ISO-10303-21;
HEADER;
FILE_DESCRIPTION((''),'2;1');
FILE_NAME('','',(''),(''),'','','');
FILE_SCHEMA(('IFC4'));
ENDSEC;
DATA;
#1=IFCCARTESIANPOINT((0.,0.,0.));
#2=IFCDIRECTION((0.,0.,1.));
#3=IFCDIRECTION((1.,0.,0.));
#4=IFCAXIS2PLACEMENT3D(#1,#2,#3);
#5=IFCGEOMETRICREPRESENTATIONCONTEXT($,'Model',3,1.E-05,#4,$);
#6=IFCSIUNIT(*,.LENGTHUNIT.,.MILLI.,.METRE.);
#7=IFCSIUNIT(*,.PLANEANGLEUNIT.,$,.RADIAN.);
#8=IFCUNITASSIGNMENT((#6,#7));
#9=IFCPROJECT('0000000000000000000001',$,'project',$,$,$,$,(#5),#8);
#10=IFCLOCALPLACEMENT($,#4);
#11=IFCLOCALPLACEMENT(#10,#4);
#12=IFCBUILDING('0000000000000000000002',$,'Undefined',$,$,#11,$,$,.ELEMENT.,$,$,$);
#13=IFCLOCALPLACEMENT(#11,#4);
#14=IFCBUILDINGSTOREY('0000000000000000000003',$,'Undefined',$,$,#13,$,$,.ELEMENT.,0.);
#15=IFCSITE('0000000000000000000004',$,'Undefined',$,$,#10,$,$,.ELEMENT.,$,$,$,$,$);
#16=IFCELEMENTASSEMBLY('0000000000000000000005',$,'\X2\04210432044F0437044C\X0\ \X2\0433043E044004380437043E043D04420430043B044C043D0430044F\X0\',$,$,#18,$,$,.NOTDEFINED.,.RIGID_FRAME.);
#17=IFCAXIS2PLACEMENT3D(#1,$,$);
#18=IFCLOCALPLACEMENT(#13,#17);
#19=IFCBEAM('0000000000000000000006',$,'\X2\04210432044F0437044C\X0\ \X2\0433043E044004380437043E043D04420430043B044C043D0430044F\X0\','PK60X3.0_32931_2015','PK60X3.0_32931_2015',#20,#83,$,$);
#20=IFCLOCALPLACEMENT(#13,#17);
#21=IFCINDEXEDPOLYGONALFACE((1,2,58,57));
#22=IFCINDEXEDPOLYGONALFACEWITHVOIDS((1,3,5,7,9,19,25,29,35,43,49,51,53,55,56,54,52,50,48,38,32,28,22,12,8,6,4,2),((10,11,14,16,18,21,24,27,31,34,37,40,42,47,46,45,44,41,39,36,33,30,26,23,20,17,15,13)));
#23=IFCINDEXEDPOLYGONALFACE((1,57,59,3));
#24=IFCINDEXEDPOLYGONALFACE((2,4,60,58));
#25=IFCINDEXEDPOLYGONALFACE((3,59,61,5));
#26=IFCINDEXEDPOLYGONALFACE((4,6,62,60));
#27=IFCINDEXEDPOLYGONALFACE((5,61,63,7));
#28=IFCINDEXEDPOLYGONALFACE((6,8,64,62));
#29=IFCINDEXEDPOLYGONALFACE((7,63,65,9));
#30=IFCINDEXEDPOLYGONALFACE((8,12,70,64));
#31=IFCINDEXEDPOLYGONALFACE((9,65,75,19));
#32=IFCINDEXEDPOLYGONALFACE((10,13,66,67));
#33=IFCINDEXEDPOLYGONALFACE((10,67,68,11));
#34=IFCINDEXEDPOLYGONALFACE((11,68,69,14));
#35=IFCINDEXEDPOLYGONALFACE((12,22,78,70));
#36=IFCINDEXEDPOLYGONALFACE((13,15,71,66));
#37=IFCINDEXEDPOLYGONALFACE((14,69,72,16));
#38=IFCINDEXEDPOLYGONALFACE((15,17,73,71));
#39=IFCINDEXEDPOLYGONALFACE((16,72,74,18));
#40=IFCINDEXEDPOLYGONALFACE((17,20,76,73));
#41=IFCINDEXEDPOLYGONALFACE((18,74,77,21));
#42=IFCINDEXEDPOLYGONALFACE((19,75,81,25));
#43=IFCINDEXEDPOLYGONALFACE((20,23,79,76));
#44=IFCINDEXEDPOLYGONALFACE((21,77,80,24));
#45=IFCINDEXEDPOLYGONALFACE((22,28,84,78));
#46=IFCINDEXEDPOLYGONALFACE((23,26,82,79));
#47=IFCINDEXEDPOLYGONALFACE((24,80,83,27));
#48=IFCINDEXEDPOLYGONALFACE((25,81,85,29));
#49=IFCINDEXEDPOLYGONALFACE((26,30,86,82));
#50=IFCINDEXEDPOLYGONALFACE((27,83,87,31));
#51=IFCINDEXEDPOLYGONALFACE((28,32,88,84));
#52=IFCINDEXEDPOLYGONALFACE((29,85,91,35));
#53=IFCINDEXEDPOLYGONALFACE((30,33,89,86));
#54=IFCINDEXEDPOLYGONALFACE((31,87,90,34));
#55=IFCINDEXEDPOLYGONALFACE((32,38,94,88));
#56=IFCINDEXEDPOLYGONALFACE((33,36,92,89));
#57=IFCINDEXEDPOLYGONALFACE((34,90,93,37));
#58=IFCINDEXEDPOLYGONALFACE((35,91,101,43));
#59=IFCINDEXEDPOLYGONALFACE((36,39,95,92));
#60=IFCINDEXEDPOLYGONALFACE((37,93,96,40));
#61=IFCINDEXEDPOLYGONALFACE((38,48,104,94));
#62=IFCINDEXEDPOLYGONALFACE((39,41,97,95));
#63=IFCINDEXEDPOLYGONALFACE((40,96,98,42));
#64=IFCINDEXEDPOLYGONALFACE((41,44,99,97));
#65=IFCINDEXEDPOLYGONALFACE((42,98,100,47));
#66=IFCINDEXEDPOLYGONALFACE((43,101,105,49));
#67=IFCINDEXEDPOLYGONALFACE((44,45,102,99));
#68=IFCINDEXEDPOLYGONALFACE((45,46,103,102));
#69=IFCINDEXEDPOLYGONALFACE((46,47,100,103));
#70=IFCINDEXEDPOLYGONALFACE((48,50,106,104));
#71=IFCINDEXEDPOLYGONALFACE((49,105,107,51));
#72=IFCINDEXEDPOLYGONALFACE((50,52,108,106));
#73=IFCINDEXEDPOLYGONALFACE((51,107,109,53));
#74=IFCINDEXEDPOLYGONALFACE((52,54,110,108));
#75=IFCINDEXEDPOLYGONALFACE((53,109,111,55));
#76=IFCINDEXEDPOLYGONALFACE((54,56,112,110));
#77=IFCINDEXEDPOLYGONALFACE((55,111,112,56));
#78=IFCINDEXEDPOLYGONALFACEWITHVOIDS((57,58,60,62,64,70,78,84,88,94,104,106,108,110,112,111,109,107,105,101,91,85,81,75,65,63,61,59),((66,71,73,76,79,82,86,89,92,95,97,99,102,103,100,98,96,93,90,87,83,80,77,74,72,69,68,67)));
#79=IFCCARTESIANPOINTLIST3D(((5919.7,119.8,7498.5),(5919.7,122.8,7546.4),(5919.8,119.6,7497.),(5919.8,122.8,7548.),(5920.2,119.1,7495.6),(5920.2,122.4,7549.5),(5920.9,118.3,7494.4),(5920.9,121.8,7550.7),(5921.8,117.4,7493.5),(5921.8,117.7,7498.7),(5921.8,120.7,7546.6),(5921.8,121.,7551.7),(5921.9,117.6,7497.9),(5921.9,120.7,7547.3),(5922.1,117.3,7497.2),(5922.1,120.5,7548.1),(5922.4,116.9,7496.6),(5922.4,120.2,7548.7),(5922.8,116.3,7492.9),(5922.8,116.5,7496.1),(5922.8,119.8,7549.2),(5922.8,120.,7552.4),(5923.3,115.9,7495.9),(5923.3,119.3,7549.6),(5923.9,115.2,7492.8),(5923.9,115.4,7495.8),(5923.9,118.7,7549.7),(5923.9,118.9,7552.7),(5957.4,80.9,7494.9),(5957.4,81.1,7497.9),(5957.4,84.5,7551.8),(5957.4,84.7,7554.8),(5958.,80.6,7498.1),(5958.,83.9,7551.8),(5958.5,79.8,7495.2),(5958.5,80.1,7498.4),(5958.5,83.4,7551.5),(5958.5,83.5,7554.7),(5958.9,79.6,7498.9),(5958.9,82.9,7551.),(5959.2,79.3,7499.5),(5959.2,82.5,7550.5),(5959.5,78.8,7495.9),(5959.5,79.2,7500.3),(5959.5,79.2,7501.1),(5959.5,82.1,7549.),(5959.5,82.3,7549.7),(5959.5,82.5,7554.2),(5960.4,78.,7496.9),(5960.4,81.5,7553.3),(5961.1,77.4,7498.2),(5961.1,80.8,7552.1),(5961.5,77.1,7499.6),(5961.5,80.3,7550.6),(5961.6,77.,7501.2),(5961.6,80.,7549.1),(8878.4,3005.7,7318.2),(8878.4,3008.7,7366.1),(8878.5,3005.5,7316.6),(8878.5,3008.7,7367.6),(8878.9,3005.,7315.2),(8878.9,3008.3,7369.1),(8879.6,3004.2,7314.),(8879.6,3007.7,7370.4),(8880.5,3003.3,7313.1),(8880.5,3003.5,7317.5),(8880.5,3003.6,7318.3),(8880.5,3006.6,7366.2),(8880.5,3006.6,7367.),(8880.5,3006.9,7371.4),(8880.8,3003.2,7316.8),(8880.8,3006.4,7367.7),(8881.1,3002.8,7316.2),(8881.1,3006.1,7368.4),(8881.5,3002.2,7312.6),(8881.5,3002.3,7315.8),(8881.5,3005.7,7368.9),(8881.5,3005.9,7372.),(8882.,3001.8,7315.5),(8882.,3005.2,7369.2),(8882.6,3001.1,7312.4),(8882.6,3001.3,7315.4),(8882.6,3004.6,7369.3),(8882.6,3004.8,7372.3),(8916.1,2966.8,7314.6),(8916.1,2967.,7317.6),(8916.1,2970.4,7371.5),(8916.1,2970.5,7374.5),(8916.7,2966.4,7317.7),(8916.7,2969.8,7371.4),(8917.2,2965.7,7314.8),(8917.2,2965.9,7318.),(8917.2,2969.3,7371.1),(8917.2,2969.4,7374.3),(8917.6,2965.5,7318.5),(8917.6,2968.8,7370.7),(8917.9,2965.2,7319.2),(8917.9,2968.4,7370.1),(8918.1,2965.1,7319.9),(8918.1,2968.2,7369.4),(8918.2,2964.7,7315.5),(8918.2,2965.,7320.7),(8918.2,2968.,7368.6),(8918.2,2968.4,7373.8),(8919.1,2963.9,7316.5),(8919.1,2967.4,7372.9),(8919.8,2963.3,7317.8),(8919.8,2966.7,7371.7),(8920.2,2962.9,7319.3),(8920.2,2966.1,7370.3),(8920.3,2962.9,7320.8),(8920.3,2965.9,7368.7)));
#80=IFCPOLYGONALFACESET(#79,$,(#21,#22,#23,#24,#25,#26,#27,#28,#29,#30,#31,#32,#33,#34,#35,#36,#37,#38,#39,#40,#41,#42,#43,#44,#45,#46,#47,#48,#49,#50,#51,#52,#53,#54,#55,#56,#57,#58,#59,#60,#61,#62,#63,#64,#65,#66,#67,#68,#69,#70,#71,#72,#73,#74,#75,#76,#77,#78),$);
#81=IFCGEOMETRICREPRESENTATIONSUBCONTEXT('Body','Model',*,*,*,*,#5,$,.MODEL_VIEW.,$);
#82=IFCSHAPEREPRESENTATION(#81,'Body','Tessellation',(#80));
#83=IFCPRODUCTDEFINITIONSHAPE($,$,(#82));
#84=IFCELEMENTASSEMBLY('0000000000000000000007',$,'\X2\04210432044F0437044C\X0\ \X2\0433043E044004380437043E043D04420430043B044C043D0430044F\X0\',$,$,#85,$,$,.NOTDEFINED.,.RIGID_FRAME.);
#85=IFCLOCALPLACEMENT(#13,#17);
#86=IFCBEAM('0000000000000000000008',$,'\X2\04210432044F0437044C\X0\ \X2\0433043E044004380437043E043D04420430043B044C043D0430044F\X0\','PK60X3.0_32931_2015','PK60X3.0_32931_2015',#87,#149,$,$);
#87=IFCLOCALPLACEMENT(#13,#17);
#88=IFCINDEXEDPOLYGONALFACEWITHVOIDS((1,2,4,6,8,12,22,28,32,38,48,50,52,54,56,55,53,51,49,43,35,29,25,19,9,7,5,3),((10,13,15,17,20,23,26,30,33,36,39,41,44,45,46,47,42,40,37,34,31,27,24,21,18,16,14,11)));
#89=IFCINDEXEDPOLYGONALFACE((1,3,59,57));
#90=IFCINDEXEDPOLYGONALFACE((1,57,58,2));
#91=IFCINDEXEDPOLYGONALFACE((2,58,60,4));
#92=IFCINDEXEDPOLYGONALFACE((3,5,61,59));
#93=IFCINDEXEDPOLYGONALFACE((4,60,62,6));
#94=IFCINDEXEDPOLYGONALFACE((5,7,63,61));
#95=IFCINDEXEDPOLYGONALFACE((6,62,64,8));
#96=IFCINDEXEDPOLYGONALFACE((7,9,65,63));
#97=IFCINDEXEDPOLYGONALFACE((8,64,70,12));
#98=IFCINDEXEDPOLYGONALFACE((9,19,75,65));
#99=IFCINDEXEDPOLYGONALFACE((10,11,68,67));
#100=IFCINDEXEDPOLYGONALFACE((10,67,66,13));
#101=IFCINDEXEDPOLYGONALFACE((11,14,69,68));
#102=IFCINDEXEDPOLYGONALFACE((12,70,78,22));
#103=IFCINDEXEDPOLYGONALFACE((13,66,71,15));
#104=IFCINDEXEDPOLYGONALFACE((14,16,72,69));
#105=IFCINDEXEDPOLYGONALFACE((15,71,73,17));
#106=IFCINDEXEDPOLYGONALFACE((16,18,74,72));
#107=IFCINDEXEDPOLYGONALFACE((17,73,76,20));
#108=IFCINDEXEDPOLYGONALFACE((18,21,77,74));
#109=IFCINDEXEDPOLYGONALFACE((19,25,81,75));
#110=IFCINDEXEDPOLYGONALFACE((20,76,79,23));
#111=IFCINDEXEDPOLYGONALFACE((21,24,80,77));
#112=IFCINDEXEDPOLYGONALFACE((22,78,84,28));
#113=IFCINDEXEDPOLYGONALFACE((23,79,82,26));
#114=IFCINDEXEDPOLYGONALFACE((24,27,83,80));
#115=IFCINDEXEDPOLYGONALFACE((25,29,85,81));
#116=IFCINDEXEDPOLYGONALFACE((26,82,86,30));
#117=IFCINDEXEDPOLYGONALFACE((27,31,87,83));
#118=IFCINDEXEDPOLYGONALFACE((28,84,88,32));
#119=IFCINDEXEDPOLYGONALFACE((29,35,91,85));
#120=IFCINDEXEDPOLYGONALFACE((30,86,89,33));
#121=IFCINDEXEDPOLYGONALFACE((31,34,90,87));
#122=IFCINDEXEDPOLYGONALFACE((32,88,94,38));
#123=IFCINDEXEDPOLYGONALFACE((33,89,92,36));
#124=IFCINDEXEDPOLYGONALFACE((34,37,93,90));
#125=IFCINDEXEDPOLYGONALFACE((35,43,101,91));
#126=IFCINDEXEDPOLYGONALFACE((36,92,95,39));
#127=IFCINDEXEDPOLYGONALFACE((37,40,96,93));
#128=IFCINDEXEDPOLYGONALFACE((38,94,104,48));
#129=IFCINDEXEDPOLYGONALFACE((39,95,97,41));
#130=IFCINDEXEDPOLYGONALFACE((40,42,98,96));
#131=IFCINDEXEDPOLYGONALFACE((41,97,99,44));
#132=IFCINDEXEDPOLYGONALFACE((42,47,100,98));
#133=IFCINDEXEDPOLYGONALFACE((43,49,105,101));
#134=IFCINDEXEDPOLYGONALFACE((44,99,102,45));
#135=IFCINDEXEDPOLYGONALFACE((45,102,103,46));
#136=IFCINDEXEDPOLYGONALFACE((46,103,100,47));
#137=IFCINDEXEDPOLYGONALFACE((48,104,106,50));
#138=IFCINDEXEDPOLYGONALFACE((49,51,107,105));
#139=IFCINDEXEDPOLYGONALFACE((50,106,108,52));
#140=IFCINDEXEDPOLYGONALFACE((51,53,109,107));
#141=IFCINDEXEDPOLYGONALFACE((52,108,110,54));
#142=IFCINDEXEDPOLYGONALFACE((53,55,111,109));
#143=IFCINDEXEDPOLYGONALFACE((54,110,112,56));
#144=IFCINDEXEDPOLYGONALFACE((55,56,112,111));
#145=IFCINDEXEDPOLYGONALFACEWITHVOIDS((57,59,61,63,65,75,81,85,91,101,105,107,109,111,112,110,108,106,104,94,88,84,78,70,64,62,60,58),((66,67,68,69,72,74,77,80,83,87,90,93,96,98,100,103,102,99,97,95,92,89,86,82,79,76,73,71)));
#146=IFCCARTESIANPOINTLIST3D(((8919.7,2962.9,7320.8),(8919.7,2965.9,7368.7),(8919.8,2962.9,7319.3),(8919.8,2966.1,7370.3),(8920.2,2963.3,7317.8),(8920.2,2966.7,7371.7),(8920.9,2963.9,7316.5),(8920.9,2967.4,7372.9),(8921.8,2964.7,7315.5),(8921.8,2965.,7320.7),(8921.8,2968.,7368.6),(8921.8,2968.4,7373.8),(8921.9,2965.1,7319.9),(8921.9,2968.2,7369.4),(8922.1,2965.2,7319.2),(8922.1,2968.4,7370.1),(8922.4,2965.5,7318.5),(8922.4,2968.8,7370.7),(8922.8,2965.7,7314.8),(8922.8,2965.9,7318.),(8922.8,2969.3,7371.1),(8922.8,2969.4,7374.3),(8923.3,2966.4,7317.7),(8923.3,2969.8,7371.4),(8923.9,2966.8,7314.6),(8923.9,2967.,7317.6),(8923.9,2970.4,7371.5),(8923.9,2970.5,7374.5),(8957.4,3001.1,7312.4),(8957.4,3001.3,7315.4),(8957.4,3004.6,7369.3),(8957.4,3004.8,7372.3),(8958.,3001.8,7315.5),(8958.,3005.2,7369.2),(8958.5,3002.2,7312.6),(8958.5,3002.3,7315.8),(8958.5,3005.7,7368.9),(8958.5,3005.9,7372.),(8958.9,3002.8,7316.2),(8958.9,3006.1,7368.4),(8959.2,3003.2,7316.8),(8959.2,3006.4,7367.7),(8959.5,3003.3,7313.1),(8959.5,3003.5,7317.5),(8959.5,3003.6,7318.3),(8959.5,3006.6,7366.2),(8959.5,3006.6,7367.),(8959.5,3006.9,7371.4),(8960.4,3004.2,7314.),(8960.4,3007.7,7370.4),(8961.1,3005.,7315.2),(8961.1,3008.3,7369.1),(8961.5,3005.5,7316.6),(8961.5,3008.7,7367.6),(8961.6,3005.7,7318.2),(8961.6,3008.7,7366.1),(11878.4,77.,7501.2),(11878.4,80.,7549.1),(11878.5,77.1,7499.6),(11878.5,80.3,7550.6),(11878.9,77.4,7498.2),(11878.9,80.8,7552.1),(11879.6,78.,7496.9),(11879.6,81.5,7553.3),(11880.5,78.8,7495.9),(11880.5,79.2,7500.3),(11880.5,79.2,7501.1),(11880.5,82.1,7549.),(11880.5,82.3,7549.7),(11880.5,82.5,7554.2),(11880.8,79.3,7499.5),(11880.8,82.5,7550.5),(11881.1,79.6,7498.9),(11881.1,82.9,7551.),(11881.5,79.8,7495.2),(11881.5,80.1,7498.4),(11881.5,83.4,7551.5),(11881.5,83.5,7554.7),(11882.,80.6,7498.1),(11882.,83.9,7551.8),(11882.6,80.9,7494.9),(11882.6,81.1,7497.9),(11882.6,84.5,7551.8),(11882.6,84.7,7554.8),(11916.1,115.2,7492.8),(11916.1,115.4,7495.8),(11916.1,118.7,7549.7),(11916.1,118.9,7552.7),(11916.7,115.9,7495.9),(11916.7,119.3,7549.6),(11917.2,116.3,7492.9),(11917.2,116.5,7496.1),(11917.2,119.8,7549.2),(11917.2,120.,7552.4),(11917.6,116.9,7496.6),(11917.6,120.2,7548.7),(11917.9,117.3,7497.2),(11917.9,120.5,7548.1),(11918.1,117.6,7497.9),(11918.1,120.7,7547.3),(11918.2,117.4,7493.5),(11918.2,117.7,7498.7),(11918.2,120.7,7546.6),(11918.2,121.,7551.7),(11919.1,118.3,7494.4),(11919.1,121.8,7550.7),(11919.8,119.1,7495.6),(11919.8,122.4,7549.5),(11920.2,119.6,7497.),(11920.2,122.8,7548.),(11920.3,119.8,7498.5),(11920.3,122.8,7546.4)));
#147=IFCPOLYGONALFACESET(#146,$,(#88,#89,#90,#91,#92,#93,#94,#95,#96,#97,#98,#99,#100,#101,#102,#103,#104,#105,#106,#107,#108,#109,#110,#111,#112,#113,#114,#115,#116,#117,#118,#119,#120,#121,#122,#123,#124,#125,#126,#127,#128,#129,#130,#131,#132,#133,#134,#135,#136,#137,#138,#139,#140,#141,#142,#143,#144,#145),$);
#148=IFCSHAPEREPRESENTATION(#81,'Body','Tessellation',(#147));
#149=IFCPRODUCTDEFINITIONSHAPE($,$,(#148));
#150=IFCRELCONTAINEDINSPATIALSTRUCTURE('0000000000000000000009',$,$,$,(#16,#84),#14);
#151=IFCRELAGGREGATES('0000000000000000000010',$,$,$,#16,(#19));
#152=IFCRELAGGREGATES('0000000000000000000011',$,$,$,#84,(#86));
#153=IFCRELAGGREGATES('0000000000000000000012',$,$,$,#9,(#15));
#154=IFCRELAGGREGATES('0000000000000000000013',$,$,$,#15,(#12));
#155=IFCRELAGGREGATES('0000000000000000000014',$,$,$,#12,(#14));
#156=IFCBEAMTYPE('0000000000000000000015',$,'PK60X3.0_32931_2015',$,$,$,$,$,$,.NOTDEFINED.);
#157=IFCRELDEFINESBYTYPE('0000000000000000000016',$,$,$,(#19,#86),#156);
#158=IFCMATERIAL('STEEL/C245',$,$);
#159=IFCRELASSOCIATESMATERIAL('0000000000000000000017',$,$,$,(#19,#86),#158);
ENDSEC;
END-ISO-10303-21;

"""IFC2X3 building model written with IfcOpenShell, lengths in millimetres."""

from ifc_helpers import new_model, si_unit, frame, origin_with_axes, origin_2d_with_axis, place, context, subcontext, project, spatial, hollow_rectangle, extrude, material, type_object, element, aggregate, save


model = new_model("IFC2X3")

# Units and contexts
model_context = context("Model", 3, precision=1e-05, world=origin_with_axes())
body_context = subcontext(model_context, "Body", "Model", "MODEL_VIEW")
ifc_project = project(units=[si_unit("LENGTHUNIT", "METRE", prefix="MILLI"), si_unit("PLANEANGLEUNIT", "RADIAN")], contexts=[model_context])

# Site, building, storey
site_placement = place(None, origin_with_axes())
site = spatial("IfcSite", under=ifc_project, at=site_placement, Name="Undefined", CompositionType="ELEMENT")
building_placement = place(site_placement, origin_with_axes())
building = spatial("IfcBuilding", under=site, at=building_placement, Name="Undefined", CompositionType="ELEMENT")
storey_placement = place(building_placement, origin_with_axes())
storey = spatial("IfcBuildingStorey", under=building, at=storey_placement, Name="Undefined", CompositionType="ELEMENT", Elevation=0.0)

# Shared definitions
ifc_material = material(Name="STEEL/C245")

# Element assemblies, beams
beam_type_1 = type_object("IfcBeamType", Name="PK60X3.0_32931_2015", PredefinedType="NOTDEFINED")
assembly_1_placement = place(storey_placement, origin_with_axes())
assembly_1 = element("IfcElementAssembly", 1, at=assembly_1_placement, inside=storey, Name="Связь горизонтальная", AssemblyPlace="NOTDEFINED", PredefinedType="RIGID_FRAME")
beam_1_placement = place(assembly_1_placement, frame((5940.7, 99.9, 7523.8), z_axis=(0.0, 0.062378, 0.998053), x_axis=(0.715179, 0.69758, -0.043599)))
beam_1 = element("IfcBeam", 2, at=beam_1_placement, type_object=beam_type_1, material=ifc_material, Name="Связь горизонтальная", Description="PK60X3.0_32931_2015", ObjectType="PK60X3.0_32931_2015", context=body_context, shape_type="SweptSolid", body=[
    extrude(hollow_rectangle(XDim=60.0, YDim=60.0, WallThickness=3.0, InnerFilletRadius=3.0, OuterFilletRadius=6.0, at=origin_2d_with_axis()), frame((4137.0, 0.0, 0.0), z_axis=(-1.0, 0.0, 0.0), x_axis=(0.0, -1.0, 0.0)), (0.0, 0.0, 1.0), 4137.0),
])
aggregate(assembly_1, [beam_1])
assembly_2_placement = place(storey_placement, origin_with_axes())
assembly_2 = element("IfcElementAssembly", 3, at=assembly_2_placement, inside=storey, Name="Связь горизонтальная", AssemblyPlace="NOTDEFINED", PredefinedType="RIGID_FRAME")
beam_2_placement = place(assembly_2_placement, frame((11899.3, 99.9, 7523.8), z_axis=(0.0, 0.062378, 0.998053), x_axis=(-0.715179, 0.69758, -0.043599)))
beam_2 = element("IfcBeam", 4, at=beam_2_placement, type_object=beam_type_1, material=ifc_material, Name="Связь горизонтальная", Description="PK60X3.0_32931_2015", ObjectType="PK60X3.0_32931_2015", context=body_context, shape_type="SweptSolid", body=[
    extrude(hollow_rectangle(XDim=60.0, YDim=60.0, WallThickness=3.0, InnerFilletRadius=3.0, OuterFilletRadius=6.0, at=origin_2d_with_axis()), frame((4137.0, 0.0, 0.0), z_axis=(-1.0, 0.0, 0.0), x_axis=(0.0, -1.0, 0.0)), (0.0, 0.0, 1.0), 4137.0),
])
aggregate(assembly_2, [beam_2])

save(model, "model.ifc")
